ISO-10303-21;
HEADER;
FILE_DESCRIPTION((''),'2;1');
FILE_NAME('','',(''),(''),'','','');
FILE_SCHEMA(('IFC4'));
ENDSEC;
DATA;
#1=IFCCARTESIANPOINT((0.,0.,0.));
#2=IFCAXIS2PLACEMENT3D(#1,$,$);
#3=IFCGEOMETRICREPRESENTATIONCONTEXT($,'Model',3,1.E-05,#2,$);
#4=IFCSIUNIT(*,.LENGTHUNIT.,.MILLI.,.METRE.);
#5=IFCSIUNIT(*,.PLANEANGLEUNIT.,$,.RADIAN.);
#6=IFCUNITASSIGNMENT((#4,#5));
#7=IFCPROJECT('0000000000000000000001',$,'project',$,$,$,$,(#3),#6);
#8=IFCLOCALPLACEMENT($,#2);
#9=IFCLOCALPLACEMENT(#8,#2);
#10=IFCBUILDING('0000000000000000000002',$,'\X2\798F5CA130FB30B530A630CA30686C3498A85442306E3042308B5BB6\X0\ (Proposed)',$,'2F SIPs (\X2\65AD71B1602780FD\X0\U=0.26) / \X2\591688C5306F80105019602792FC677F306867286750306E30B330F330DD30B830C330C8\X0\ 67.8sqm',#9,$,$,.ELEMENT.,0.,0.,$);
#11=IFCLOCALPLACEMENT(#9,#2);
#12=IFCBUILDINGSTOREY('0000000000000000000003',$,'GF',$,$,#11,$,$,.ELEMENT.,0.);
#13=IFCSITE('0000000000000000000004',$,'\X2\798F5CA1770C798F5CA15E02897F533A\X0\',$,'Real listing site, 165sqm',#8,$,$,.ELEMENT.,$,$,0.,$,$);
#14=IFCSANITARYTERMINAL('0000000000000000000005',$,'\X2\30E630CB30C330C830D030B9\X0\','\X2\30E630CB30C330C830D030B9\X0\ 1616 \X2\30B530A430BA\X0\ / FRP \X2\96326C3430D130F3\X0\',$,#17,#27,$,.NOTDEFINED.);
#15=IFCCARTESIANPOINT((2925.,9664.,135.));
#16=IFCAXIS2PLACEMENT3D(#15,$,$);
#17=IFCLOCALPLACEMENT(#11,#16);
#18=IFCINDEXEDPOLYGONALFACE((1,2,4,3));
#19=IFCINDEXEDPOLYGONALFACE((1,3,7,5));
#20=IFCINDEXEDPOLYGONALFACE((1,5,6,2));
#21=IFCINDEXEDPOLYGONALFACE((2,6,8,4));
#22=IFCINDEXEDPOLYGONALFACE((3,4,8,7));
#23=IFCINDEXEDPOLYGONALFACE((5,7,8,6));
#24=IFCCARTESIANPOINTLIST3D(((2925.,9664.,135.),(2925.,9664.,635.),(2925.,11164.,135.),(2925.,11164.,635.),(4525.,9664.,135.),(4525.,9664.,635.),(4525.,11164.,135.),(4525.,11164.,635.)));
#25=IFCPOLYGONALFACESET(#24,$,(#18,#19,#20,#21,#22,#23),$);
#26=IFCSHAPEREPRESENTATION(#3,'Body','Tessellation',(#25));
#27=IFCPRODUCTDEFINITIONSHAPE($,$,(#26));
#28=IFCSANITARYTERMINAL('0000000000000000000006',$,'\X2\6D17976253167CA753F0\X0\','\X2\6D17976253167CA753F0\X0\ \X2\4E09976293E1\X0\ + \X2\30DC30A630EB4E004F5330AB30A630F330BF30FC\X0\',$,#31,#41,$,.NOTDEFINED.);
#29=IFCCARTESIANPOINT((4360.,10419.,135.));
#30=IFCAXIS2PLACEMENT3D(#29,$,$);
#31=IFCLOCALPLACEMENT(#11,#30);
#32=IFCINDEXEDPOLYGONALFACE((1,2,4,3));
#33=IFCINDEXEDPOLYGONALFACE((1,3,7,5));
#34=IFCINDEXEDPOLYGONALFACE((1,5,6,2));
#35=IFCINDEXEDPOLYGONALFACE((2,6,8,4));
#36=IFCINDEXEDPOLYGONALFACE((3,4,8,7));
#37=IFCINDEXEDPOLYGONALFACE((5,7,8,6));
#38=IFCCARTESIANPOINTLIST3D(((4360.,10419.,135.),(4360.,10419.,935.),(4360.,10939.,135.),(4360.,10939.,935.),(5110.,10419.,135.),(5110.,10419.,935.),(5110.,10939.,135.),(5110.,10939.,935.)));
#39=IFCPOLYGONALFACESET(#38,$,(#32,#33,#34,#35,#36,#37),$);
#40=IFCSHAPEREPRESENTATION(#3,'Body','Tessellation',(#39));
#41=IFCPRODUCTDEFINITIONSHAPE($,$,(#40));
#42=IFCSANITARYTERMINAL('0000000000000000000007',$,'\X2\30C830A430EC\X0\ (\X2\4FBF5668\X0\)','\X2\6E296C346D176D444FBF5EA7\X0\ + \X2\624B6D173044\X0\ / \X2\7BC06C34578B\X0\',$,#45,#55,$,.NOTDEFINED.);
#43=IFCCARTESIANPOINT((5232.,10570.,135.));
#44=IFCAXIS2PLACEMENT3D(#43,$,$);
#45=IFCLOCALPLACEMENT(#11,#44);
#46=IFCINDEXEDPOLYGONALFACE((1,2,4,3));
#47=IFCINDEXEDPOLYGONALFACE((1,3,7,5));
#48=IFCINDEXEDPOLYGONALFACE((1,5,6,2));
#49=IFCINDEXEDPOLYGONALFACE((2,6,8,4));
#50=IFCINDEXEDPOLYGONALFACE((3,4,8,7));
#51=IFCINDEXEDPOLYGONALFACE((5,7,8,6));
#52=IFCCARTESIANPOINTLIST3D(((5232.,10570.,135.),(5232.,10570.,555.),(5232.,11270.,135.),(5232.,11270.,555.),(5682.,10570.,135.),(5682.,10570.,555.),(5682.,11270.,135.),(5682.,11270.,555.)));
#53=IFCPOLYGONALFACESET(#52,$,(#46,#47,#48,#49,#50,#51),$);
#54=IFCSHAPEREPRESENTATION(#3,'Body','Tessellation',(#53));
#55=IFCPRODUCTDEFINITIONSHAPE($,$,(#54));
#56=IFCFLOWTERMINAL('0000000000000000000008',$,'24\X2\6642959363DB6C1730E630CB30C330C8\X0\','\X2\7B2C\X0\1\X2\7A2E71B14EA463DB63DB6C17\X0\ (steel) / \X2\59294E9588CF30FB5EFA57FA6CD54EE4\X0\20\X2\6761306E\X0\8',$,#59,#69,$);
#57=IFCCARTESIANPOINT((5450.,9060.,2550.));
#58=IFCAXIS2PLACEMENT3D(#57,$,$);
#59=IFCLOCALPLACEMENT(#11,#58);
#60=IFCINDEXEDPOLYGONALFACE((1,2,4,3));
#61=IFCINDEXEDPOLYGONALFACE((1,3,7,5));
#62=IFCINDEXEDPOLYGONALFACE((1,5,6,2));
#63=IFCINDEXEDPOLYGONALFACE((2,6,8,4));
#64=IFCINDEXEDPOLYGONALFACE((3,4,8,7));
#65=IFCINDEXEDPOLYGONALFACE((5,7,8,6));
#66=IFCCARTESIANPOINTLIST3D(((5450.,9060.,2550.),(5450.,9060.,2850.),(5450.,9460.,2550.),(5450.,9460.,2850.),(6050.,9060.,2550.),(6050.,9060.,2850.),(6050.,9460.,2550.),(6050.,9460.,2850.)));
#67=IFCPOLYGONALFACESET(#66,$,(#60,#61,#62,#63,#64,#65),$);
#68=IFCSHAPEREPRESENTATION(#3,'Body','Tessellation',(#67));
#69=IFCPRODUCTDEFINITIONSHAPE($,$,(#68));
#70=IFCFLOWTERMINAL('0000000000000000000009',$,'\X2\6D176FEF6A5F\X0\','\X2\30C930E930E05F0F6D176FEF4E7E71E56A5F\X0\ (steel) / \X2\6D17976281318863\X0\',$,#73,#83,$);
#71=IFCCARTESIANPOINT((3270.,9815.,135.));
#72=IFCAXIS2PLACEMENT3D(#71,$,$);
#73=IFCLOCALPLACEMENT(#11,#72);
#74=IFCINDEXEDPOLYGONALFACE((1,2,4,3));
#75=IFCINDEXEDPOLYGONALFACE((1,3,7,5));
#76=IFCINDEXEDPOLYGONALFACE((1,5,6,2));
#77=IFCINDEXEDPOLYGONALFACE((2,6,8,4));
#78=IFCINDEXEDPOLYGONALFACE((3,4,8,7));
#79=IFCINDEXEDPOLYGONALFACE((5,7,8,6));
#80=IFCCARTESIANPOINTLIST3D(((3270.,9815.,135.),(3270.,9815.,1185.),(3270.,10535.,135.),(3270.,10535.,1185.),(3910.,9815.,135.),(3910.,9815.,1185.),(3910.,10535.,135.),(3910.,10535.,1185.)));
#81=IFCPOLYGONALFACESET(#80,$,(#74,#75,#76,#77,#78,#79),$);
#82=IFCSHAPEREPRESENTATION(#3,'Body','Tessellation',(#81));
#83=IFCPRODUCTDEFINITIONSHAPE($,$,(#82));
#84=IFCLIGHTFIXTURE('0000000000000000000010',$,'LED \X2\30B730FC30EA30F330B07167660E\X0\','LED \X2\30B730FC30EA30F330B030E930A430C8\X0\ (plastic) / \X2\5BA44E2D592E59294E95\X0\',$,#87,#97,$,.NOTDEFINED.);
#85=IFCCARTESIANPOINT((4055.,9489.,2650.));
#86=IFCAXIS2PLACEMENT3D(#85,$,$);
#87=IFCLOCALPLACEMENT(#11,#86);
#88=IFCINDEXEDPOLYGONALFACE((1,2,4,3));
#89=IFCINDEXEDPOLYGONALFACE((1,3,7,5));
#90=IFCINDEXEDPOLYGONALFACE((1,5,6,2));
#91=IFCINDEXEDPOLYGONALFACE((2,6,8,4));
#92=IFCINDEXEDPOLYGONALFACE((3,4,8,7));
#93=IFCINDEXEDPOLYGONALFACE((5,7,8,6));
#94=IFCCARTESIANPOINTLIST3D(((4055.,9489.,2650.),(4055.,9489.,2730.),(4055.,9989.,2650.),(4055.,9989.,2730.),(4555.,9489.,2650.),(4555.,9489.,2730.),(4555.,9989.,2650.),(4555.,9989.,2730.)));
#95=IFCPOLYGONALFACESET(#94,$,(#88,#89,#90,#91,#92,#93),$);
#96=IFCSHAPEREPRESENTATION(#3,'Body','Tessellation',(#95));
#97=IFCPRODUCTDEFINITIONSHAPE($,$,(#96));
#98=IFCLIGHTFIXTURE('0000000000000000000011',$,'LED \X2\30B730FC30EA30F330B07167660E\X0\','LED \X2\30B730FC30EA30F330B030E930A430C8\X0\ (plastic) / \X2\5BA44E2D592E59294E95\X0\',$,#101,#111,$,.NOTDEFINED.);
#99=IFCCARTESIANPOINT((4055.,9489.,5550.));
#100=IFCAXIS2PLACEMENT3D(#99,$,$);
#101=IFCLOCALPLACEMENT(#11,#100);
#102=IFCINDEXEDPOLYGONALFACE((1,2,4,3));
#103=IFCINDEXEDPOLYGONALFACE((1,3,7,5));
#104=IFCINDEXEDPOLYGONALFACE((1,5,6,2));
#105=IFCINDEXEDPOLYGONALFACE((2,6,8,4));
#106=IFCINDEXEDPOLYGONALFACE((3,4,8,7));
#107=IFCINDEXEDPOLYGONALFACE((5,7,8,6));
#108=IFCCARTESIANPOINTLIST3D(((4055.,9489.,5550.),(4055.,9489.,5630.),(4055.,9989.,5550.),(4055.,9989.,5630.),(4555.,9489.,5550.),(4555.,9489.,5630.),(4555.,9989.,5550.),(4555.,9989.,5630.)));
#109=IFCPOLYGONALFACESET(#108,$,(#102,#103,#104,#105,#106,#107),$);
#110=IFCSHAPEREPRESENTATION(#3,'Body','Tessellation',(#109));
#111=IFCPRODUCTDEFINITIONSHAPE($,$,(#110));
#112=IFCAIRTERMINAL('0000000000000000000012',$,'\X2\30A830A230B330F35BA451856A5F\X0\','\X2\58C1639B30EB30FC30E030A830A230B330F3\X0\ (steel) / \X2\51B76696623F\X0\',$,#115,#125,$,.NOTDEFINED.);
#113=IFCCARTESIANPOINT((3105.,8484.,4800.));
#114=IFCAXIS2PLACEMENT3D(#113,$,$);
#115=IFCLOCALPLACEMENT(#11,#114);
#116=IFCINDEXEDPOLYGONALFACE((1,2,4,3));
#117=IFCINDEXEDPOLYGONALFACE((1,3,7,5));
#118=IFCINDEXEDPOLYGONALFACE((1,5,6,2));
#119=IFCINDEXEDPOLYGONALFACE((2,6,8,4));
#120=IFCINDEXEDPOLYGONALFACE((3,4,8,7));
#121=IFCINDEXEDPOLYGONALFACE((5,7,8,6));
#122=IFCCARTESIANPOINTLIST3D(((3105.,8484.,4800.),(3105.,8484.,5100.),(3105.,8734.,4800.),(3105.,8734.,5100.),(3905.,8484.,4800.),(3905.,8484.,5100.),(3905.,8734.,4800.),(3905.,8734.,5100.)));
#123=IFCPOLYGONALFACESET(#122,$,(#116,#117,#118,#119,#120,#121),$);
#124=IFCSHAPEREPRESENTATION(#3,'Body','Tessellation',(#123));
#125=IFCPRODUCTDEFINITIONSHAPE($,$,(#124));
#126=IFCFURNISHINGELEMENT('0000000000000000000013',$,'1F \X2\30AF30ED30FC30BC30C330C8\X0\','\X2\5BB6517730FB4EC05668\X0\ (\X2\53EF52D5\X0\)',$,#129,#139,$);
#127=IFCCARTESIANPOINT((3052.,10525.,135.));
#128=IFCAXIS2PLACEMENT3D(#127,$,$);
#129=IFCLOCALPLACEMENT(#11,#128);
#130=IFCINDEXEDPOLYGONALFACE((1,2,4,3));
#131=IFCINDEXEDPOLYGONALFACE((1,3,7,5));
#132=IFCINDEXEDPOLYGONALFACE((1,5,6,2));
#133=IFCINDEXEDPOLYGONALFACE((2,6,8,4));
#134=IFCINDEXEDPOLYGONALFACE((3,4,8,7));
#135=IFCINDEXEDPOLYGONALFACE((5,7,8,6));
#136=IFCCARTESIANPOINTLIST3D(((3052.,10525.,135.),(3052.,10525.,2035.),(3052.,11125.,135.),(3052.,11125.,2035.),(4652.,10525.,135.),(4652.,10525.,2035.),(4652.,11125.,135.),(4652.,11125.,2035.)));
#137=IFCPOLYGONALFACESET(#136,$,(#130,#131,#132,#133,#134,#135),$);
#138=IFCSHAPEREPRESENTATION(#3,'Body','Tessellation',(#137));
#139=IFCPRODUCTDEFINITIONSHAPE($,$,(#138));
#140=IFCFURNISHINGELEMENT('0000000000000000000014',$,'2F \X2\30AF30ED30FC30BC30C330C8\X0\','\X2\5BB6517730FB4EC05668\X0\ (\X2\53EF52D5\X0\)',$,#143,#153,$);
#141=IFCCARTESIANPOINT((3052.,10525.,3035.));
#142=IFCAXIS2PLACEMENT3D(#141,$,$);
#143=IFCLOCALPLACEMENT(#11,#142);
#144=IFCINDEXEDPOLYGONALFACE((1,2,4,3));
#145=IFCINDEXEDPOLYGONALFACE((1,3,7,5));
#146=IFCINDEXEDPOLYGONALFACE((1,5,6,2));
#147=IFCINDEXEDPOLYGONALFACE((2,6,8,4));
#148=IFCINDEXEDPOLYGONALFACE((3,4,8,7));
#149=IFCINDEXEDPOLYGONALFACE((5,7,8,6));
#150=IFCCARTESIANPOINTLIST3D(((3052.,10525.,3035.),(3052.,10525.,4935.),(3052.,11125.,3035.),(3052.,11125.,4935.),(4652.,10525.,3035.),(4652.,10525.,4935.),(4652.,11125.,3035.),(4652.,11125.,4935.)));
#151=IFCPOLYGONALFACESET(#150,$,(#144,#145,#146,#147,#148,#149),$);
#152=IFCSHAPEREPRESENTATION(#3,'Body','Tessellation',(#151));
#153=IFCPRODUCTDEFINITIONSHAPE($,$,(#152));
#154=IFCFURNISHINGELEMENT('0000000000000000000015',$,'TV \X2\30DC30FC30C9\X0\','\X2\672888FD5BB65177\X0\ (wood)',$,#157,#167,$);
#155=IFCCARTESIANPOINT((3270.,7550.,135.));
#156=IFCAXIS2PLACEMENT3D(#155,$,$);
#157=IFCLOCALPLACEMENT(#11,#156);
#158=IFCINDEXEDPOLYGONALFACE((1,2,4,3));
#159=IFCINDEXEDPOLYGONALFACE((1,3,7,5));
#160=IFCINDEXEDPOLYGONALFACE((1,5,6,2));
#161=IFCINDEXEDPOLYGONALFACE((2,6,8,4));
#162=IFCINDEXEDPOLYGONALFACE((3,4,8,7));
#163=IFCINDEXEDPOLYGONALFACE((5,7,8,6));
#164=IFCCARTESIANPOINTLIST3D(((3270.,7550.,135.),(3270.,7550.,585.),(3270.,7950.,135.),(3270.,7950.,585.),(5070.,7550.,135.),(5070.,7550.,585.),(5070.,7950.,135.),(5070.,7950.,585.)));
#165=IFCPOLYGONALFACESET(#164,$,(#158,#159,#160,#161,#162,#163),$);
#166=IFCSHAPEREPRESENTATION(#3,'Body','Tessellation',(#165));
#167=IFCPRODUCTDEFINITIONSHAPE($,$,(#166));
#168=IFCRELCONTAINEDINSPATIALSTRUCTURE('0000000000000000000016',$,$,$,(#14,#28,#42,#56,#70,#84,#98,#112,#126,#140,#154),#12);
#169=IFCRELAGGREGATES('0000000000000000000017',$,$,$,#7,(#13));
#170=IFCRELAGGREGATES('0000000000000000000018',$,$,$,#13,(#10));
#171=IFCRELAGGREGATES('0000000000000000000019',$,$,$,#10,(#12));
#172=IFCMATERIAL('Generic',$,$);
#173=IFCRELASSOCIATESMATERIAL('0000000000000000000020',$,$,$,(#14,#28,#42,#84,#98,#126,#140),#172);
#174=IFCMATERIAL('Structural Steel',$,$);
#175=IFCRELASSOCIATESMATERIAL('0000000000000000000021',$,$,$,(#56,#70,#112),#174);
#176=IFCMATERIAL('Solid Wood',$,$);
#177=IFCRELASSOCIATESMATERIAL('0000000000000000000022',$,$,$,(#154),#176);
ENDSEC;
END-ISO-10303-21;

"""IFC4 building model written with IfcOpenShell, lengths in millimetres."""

from ifc_helpers import new_model, si_unit, frame, frame_2d, origin, place, context, project, spatial, rectangle, extrude, material, element, save


model = new_model("IFC4")

# Units and contexts
model_context = context("Model", 3, precision=1e-05, world=origin())
ifc_project = project(units=[si_unit("LENGTHUNIT", "METRE", prefix="MILLI"), si_unit("PLANEANGLEUNIT", "RADIAN")], contexts=[model_context])

# Site, building, storey
site_placement = place(None, origin())
site = spatial("IfcSite", under=ifc_project, at=site_placement, Name="福岡県福岡市西区", ObjectType="Real listing site, 165sqm", CompositionType="ELEMENT", RefElevation=0.0)
building_placement = place(site_placement, origin())
building = spatial("IfcBuilding", under=site, at=building_placement, Name="福岡・サウナと水風呂のある家 (Proposed)", ObjectType="2F SIPs (断熱性能U=0.26) / 外装は耐候性鋼板と木材のコンポジット 67.8sqm", CompositionType="ELEMENT", ElevationOfRefHeight=0.0, ElevationOfTerrain=0.0)
storey_placement = place(building_placement, origin())
storey = spatial("IfcBuildingStorey", under=building, at=storey_placement, Name="GF", CompositionType="ELEMENT", Elevation=0.0)

# Shared definitions
ifc_material_1 = material(Name="Solid Wood")

# Sanitary terminals
ifc_material_2 = material(Name="Generic")
sanitary_terminal_1_placement = place(storey_placement, frame((2925.0, 9664.0, 135.0)))
element("IfcSanitaryTerminal", 1, at=sanitary_terminal_1_placement, inside=storey, material=ifc_material_2, Name="ユニットバス", Description="ユニットバス 1616 サイズ / FRP 防水パン", PredefinedType="NOTDEFINED", context=model_context, shape_type="SweptSolid", body=[
    extrude(rectangle(XDim=1600.0, YDim=1500.0, at=frame_2d((800.0, 750.0))), frame((2925.0, 9664.0, 135.0)), (0.0, 0.0, 1.0), 500.0),
])
sanitary_terminal_2_placement = place(storey_placement, frame((4360.0, 10419.0, 135.0)))
element("IfcSanitaryTerminal", 2, at=sanitary_terminal_2_placement, inside=storey, material=ifc_material_2, Name="洗面化粧台", Description="洗面化粧台 三面鏡 + ボウル一体カウンター", PredefinedType="NOTDEFINED", context=model_context, shape_type="SweptSolid", body=[
    extrude(rectangle(XDim=750.0, YDim=520.0, at=frame_2d((375.0, 260.0))), frame((4360.0, 10419.0, 135.0)), (0.0, 0.0, 1.0), 800.0),
])
sanitary_terminal_3_placement = place(storey_placement, frame((5232.0, 10570.0, 135.0)))
element("IfcSanitaryTerminal", 3, at=sanitary_terminal_3_placement, inside=storey, material=ifc_material_2, Name="トイレ (便器)", Description="温水洗浄便座 + 手洗い / 節水型", PredefinedType="NOTDEFINED", context=model_context, shape_type="SweptSolid", body=[
    extrude(rectangle(XDim=450.0, YDim=700.0, at=frame_2d((225.0, 350.0))), frame((5232.0, 10570.0, 135.0)), (0.0, 0.0, 1.0), 420.0),
])

# Flow terminals
ifc_material_3 = material(Name="Structural Steel")
flow_terminal_1_placement = place(storey_placement, frame((5450.0, 9060.0, 2550.0)))
element("IfcFlowTerminal", 4, at=flow_terminal_1_placement, inside=storey, material=ifc_material_3, Name="24時間換気ユニット", Description="第1種熱交換換気 (steel) / 天井裏・建基法令20条の8", context=model_context, shape_type="SweptSolid", body=[
    extrude(rectangle(XDim=600.0, YDim=400.0, at=frame_2d((300.0, 200.0))), frame((5450.0, 9060.0, 2550.0)), (0.0, 0.0, 1.0), 300.0),
])
flow_terminal_2_placement = place(storey_placement, frame((3270.0, 9815.0, 135.0)))
element("IfcFlowTerminal", 5, at=flow_terminal_2_placement, inside=storey, material=ifc_material_3, Name="洗濯機", Description="ドラム式洗濯乾燥機 (steel) / 洗面脱衣", context=model_context, shape_type="SweptSolid", body=[
    extrude(rectangle(XDim=640.0, YDim=720.0, at=frame_2d((320.0, 360.0))), frame((3270.0, 9815.0, 135.0)), (0.0, 0.0, 1.0), 1050.0),
])

# Light fixtures
light_fixture_1_placement = place(storey_placement, frame((4055.0, 9489.0, 2650.0)))
element("IfcLightFixture", 6, at=light_fixture_1_placement, inside=storey, material=ifc_material_2, Name="LED シーリング照明", Description="LED シーリングライト (plastic) / 室中央天井", PredefinedType="NOTDEFINED", context=model_context, shape_type="SweptSolid", body=[
    extrude(rectangle(XDim=500.0, YDim=500.0, at=frame_2d((250.0, 250.0))), frame((4055.0, 9489.0, 2650.0)), (0.0, 0.0, 1.0), 80.0),
])
light_fixture_2_placement = place(storey_placement, frame((4055.0, 9489.0, 5550.0)))
element("IfcLightFixture", 7, at=light_fixture_2_placement, inside=storey, material=ifc_material_2, Name="LED シーリング照明", Description="LED シーリングライト (plastic) / 室中央天井", PredefinedType="NOTDEFINED", context=model_context, shape_type="SweptSolid", body=[
    extrude(rectangle(XDim=500.0, YDim=500.0, at=frame_2d((250.0, 250.0))), frame((4055.0, 9489.0, 5550.0)), (0.0, 0.0, 1.0), 80.0),
])

# Air terminal
air_terminal_placement = place(storey_placement, frame((3105.0, 8484.0, 4800.0)))
element("IfcAirTerminal", 8, at=air_terminal_placement, inside=storey, material=ifc_material_3, Name="エアコン室内機", Description="壁掛ルームエアコン (steel) / 冷暖房", PredefinedType="NOTDEFINED", context=model_context, shape_type="SweptSolid", body=[
    extrude(rectangle(XDim=800.0, YDim=250.0, at=frame_2d((400.0, 125.0))), frame((3105.0, 8484.0, 4800.0)), (0.0, 0.0, 1.0), 300.0),
])

# Furnishing elements
furnishing_1_placement = place(storey_placement, frame((3052.0, 10525.0, 135.0)))
element("IfcFurnishingElement", 9, at=furnishing_1_placement, inside=storey, material=ifc_material_2, Name="1F クローゼット", Description="家具・什器 (可動)", context=model_context, shape_type="SweptSolid", body=[
    extrude(rectangle(XDim=1600.0, YDim=600.0, at=frame_2d((800.0, 300.0))), frame((3052.0, 10525.0, 135.0)), (0.0, 0.0, 1.0), 1900.0),
])
furnishing_2_placement = place(storey_placement, frame((3052.0, 10525.0, 3035.0)))
element("IfcFurnishingElement", 10, at=furnishing_2_placement, inside=storey, material=ifc_material_2, Name="2F クローゼット", Description="家具・什器 (可動)", context=model_context, shape_type="SweptSolid", body=[
    extrude(rectangle(XDim=1600.0, YDim=600.0, at=frame_2d((800.0, 300.0))), frame((3052.0, 10525.0, 3035.0)), (0.0, 0.0, 1.0), 1900.0),
])
furnishing_3_placement = place(storey_placement, frame((3270.0, 7550.0, 135.0)))
element("IfcFurnishingElement", 11, at=furnishing_3_placement, inside=storey, material=ifc_material_1, Name="TV ボード", Description="木製家具 (wood)", context=model_context, shape_type="SweptSolid", body=[
    extrude(rectangle(XDim=1800.0, YDim=400.0, at=frame_2d((900.0, 200.0))), frame((3270.0, 7550.0, 135.0)), (0.0, 0.0, 1.0), 450.0),
])

save(model, "model.ifc")
